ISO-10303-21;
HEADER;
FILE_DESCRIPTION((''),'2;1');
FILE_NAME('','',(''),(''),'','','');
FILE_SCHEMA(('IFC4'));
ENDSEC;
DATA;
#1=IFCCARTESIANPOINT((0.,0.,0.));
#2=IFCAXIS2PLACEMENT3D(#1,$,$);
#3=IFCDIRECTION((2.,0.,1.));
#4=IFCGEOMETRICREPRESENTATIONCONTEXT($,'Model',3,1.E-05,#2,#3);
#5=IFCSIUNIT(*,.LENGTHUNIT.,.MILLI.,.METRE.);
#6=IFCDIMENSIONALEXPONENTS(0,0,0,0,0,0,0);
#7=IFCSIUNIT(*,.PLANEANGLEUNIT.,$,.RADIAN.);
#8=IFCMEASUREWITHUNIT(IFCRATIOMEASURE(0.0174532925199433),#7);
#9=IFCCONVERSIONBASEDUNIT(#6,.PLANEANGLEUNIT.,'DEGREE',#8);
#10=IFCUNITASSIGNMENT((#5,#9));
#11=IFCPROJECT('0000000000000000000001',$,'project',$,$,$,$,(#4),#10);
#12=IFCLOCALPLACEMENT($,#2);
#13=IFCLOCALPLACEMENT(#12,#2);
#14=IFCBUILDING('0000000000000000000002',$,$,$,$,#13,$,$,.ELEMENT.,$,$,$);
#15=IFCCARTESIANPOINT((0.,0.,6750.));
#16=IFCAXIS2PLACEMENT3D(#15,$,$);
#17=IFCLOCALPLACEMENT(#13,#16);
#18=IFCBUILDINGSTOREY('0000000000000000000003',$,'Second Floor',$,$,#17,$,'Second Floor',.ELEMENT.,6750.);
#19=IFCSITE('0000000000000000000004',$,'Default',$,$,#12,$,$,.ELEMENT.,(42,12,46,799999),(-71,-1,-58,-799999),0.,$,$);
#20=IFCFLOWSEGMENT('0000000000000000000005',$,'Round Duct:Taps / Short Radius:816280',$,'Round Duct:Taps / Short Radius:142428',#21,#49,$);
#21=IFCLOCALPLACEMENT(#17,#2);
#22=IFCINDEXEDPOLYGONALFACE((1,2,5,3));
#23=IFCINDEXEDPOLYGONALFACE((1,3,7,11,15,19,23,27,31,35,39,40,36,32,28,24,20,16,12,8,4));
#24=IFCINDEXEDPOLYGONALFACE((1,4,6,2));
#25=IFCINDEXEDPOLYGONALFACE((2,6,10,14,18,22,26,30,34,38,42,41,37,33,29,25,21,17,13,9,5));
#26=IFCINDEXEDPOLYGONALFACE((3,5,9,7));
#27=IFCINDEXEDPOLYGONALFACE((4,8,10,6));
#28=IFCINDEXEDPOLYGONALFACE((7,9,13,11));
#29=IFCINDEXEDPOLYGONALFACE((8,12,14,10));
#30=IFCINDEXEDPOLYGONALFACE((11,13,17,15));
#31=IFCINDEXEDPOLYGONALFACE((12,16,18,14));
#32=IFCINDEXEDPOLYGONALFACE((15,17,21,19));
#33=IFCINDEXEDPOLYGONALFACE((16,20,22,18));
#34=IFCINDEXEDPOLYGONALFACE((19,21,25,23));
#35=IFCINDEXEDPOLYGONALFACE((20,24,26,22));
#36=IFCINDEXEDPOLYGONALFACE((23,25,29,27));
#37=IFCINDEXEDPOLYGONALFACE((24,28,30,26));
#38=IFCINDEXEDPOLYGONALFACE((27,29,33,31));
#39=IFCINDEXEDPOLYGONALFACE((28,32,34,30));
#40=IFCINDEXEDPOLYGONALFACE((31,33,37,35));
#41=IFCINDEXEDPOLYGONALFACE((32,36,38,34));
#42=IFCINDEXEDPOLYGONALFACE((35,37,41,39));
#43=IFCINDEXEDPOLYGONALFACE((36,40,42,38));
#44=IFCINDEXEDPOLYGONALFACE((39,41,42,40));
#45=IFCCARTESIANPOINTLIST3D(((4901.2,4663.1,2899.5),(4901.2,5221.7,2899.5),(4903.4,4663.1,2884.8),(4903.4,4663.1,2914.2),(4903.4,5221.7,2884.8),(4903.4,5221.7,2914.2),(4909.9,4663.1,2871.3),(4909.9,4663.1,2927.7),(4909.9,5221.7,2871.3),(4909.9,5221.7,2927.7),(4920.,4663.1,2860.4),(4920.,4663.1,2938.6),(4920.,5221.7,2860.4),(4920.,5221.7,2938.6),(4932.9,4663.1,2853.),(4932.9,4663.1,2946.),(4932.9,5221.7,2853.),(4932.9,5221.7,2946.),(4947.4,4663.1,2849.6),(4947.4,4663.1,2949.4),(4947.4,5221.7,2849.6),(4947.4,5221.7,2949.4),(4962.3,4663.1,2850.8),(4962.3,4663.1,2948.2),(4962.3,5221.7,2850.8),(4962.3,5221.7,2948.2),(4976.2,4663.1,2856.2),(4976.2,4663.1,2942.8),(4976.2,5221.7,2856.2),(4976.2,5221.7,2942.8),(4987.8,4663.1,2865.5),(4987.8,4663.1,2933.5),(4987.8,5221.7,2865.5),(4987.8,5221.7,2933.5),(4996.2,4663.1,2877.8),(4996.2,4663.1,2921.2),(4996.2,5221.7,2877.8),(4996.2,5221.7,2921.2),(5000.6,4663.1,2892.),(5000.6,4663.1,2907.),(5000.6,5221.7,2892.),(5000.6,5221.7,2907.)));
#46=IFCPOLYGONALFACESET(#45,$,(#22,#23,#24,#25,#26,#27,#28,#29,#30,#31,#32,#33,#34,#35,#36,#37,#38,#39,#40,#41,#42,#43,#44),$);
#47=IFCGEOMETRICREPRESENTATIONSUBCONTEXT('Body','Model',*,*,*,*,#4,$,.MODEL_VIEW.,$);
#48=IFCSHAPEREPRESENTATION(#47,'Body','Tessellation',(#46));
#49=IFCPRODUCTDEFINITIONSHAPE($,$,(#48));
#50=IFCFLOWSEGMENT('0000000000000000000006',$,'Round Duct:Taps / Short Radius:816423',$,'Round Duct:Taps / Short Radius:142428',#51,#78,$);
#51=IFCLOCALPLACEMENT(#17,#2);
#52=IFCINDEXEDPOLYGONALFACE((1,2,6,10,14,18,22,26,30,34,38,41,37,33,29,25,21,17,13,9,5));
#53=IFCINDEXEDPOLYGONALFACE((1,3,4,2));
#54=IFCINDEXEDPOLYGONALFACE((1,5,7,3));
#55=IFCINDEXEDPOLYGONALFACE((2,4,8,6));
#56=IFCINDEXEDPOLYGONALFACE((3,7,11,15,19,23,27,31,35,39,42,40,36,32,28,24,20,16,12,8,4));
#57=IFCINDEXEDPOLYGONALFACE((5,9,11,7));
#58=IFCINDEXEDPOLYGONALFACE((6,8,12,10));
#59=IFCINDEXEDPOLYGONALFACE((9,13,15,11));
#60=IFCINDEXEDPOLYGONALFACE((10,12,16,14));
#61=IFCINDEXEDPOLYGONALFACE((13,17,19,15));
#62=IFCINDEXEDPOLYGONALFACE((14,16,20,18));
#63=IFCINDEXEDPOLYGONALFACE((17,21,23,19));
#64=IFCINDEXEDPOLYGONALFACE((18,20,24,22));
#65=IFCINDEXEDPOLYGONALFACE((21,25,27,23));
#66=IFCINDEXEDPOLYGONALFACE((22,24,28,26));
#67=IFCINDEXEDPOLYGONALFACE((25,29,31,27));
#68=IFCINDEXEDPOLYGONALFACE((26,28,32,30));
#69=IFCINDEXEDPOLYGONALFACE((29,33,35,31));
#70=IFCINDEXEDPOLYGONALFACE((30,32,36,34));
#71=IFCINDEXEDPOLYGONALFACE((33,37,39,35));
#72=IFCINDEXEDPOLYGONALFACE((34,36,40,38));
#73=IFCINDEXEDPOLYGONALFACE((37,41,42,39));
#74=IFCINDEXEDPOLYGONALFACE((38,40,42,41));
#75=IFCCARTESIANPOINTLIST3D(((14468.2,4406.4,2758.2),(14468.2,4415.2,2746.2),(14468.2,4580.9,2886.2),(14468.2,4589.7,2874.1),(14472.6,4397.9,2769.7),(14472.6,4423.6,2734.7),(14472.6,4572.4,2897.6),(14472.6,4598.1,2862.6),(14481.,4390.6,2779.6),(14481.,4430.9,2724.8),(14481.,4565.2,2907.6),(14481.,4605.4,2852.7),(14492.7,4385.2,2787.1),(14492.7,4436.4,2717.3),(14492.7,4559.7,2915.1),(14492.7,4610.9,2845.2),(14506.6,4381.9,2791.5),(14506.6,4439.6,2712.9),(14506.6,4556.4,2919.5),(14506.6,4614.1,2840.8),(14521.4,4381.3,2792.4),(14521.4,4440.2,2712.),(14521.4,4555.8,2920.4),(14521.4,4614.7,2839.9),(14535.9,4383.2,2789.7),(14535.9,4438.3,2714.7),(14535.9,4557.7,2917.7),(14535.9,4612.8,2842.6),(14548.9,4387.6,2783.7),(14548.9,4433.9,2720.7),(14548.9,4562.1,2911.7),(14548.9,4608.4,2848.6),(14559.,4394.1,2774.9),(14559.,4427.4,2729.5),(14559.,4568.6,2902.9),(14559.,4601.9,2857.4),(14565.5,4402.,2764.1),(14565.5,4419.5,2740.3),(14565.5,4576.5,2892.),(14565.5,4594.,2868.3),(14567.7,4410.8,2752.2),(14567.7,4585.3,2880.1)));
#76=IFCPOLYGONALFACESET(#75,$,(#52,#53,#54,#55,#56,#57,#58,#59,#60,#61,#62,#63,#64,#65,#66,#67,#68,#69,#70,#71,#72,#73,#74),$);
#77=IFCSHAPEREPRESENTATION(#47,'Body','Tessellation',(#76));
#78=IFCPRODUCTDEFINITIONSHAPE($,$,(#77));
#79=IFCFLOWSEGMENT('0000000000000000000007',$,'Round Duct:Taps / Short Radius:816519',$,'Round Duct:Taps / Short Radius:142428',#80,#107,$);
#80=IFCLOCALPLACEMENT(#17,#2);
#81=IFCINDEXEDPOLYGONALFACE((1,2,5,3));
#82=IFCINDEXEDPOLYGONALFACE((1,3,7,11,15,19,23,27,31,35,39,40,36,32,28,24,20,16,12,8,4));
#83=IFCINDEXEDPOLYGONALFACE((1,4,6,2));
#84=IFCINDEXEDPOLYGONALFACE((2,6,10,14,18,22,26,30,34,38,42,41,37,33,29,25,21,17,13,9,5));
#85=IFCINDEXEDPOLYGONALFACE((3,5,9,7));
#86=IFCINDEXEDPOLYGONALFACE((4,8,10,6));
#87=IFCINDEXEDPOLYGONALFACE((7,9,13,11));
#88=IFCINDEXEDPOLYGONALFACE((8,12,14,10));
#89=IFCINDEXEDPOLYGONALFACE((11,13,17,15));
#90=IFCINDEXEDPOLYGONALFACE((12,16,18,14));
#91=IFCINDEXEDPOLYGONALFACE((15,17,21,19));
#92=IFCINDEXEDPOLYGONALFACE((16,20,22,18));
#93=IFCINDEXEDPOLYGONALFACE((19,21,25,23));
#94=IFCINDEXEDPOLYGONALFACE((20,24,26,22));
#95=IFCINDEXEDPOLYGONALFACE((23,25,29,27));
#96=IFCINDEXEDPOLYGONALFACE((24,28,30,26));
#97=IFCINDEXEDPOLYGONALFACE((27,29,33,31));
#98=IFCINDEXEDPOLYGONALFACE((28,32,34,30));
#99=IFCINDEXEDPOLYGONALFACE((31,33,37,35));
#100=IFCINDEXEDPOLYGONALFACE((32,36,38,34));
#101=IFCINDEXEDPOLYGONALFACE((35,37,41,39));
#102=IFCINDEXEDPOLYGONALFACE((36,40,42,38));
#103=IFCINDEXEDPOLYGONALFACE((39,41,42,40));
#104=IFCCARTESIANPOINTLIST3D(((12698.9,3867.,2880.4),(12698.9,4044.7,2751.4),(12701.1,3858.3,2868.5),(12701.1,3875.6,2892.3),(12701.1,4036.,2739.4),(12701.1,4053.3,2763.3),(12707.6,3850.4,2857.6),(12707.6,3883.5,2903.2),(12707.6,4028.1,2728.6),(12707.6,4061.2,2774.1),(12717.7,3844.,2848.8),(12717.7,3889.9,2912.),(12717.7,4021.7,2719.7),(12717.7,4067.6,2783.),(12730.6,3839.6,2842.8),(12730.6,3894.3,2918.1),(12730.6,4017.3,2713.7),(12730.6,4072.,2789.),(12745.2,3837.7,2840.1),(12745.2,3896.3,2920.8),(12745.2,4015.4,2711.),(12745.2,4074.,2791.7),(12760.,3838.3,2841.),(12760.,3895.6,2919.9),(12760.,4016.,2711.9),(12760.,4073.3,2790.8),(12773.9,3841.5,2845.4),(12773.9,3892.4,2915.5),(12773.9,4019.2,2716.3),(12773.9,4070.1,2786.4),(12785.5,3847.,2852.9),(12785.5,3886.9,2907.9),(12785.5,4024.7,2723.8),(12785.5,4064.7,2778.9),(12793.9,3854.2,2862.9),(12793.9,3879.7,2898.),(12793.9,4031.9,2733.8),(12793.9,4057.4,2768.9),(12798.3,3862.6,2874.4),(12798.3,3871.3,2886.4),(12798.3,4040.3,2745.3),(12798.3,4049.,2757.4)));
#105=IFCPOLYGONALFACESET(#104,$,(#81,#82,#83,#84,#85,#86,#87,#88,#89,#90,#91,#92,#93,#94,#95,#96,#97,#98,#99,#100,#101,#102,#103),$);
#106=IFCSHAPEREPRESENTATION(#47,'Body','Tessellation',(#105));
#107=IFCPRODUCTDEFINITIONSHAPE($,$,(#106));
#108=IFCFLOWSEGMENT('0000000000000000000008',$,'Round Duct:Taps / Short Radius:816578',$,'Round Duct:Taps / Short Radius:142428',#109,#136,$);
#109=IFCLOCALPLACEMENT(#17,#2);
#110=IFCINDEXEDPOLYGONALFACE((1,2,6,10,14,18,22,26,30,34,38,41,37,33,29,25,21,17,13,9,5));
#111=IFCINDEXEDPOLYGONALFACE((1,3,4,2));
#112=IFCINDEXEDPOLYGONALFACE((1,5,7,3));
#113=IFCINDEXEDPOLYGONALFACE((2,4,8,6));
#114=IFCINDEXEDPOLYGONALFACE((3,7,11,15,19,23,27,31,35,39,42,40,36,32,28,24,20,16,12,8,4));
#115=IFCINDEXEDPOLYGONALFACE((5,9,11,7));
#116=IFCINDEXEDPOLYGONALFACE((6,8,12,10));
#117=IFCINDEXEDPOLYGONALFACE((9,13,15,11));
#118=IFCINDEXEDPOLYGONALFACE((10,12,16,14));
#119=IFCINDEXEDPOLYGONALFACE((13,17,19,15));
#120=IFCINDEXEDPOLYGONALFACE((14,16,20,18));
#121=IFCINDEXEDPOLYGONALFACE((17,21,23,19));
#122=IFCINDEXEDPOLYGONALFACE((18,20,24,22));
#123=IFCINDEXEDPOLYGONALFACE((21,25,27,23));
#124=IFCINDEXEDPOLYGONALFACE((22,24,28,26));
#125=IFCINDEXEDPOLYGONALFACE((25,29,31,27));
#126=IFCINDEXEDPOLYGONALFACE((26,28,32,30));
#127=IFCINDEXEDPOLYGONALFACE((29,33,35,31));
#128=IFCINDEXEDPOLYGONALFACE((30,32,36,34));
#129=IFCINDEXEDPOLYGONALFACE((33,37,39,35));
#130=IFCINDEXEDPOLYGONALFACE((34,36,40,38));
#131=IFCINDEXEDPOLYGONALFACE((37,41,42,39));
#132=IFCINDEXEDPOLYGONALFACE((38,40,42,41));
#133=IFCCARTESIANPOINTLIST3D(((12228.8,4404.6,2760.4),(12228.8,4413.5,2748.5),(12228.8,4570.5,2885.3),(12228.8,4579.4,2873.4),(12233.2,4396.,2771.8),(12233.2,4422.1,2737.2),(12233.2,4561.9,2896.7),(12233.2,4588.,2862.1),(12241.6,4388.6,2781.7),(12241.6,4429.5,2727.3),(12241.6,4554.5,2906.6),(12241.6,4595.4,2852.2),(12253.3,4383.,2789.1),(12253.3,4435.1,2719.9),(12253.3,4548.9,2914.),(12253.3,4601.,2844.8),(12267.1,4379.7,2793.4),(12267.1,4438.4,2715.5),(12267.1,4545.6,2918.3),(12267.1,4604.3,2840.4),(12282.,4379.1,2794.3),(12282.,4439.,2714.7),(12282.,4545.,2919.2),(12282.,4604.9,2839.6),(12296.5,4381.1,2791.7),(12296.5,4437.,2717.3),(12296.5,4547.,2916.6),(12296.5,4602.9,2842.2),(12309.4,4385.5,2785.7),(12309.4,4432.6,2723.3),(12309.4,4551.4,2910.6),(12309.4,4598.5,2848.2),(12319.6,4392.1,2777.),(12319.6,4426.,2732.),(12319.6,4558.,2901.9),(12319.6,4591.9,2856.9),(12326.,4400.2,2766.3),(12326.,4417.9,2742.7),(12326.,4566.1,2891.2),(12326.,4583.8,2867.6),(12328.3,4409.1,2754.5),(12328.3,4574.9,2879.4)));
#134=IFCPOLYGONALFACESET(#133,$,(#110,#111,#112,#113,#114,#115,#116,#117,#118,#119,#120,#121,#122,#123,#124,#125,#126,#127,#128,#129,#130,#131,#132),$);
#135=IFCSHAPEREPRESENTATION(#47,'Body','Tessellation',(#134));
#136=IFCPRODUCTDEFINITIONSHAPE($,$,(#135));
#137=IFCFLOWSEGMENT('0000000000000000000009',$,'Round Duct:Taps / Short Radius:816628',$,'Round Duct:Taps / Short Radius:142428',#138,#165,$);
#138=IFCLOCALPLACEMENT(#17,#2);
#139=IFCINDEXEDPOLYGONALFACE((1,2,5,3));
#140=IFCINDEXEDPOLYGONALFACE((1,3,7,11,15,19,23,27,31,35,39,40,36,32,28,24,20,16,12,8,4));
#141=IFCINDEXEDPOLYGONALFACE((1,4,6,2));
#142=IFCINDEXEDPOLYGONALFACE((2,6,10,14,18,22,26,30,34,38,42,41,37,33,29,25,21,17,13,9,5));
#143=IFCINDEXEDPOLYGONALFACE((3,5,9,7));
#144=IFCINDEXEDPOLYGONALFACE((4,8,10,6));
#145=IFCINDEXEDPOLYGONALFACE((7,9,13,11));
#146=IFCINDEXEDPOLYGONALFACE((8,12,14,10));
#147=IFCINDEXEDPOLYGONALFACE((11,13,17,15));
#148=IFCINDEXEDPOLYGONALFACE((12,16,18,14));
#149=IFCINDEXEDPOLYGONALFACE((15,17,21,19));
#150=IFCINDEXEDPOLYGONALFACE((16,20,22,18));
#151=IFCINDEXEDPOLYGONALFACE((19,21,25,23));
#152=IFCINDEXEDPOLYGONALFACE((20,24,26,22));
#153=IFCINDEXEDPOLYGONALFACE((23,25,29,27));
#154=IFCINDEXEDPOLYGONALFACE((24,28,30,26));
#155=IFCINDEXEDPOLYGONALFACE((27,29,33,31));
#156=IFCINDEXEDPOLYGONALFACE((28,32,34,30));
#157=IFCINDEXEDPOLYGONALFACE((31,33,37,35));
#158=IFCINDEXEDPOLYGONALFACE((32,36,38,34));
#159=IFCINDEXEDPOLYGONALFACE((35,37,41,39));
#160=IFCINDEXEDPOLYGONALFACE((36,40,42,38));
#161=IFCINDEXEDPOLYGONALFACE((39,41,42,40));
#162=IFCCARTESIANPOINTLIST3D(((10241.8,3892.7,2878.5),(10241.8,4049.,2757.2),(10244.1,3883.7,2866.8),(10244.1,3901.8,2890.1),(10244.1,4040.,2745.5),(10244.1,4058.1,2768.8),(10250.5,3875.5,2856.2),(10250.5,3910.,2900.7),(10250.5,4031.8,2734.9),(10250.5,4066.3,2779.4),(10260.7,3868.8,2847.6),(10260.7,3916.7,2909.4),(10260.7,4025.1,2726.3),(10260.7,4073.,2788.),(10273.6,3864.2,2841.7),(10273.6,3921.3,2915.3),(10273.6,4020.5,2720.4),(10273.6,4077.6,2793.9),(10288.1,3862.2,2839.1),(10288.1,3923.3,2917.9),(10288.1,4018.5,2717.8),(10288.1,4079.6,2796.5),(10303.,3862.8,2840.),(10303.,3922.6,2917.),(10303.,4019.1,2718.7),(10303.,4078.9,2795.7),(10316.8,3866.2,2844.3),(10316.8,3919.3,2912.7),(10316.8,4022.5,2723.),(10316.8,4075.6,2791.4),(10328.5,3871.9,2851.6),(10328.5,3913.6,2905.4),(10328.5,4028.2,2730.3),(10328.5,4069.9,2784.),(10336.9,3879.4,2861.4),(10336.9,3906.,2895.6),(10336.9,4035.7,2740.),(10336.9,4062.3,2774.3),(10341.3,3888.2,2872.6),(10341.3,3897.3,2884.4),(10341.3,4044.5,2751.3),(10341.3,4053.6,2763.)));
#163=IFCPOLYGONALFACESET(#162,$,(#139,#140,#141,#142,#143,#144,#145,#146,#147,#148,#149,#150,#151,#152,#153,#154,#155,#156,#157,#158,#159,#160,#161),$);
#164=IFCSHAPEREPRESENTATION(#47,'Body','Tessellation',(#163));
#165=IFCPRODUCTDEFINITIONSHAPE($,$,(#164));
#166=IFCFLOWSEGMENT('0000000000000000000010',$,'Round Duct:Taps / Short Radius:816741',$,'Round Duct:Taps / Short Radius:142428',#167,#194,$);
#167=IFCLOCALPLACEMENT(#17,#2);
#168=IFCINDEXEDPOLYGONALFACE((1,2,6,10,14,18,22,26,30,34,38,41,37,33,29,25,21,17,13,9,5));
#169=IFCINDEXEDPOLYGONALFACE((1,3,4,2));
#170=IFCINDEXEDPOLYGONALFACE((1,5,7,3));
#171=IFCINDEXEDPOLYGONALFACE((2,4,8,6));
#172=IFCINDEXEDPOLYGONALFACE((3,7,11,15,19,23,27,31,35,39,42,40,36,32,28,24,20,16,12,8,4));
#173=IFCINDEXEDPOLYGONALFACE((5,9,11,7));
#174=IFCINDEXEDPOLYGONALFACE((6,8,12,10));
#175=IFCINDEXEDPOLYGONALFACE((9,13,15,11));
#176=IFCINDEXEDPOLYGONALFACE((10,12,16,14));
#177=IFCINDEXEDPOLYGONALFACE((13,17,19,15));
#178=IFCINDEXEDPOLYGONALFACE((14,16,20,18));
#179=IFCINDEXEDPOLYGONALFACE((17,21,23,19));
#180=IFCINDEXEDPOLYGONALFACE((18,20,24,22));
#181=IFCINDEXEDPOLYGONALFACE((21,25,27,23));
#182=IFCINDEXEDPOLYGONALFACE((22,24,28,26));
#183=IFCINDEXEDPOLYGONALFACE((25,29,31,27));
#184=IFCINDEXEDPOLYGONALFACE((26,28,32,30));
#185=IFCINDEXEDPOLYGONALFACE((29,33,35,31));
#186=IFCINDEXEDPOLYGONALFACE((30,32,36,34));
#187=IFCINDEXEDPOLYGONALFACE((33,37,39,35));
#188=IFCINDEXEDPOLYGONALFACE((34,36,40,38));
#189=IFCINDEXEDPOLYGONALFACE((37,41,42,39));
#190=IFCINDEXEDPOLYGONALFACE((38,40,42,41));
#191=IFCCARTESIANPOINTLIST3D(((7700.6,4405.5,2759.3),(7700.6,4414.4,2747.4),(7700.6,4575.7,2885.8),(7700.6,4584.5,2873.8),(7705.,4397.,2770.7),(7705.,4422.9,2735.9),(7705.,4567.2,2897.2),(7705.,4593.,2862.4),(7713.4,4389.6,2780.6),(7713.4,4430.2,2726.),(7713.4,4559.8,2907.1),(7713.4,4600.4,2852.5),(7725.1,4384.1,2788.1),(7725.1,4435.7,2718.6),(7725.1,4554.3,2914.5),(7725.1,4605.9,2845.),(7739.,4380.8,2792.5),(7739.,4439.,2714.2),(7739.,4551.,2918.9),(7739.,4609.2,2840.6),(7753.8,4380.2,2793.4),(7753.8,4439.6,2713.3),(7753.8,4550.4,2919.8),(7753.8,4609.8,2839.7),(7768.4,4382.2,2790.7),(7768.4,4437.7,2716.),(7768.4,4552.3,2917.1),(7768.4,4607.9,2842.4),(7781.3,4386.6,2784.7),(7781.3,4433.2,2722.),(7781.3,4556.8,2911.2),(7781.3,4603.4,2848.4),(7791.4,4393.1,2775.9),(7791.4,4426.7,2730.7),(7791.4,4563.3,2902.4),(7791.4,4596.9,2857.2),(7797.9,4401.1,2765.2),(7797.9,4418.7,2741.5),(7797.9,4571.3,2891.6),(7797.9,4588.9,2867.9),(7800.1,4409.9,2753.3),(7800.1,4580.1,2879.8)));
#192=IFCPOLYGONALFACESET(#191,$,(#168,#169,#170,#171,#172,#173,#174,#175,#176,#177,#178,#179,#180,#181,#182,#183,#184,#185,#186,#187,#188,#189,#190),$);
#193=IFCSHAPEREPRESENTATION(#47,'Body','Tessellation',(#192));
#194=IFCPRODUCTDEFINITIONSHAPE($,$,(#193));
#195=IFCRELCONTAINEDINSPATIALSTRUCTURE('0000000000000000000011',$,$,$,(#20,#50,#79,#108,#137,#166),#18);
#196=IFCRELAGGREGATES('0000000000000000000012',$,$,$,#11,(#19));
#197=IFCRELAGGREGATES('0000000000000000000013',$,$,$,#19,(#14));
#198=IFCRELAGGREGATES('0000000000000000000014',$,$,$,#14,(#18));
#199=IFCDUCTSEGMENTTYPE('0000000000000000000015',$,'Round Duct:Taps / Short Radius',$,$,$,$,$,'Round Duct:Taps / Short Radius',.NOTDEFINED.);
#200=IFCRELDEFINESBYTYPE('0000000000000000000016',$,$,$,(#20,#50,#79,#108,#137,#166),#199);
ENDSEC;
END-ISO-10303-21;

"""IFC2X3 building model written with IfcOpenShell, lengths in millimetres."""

from ifc_helpers import new_model, entity, si_unit, converted_unit, direction, frame, frame_2d, origin, place, context, subcontext, project, spatial, circle, extrude, type_object, element, save


model = new_model("IFC2X3")

# Units and contexts
model_context = context("Model", 3, precision=1e-05, world=origin(), true_north=direction((2.0, 0.0, 1.0)))
body_context = subcontext(model_context, "Body", "Model", "MODEL_VIEW")
ifc_project = project(units=[si_unit("LENGTHUNIT", "METRE", prefix="MILLI"), converted_unit("PLANEANGLEUNIT", "DEGREE", entity("IfcRatioMeasure", 0.0174532925199433), si_unit("PLANEANGLEUNIT", "RADIAN"), dimensions=[0, 0, 0, 0, 0, 0, 0])], contexts=[model_context])

# Site, building, storey
site_placement = place(None, origin())
site = spatial("IfcSite", under=ifc_project, at=site_placement, Name="Default", CompositionType="ELEMENT", RefLatitude=(42, 12, 46, 799999), RefLongitude=(-71, -1, -58, -799999), RefElevation=0.0)
building_placement = place(site_placement, origin())
building = spatial("IfcBuilding", under=site, at=building_placement, CompositionType="ELEMENT")
storey_placement = place(building_placement, frame((0.0, 0.0, 6750.0)))
storey = spatial("IfcBuildingStorey", under=building, at=storey_placement, Name="Second Floor", LongName="Second Floor", CompositionType="ELEMENT", Elevation=6750.0)

# Flow segments
duct_segment_type = type_object("IfcDuctSegmentType", Name="Round Duct:Taps / Short Radius", ElementType="Round Duct:Taps / Short Radius", PredefinedType="NOTDEFINED")
flow_segment_1_placement = place(storey_placement, origin())
element("IfcFlowSegment", 1, at=flow_segment_1_placement, inside=storey, type_object=duct_segment_type, Name="Round Duct:Taps / Short Radius:816280", ObjectType="Round Duct:Taps / Short Radius:142428", context=body_context, shape_type="SweptSolid", body=[
    extrude(circle(Radius=50.0, at=frame_2d((0.0, 0.0), x_axis=(1.0, 0.0))), frame((4951.2, 4663.1, 2899.5), z_axis=(0.0, 1.0, 0.0), x_axis=(-1.0, 0.0, 0.0)), (0.0, 0.0, 1.0), 558.6),
])
flow_segment_2_placement = place(storey_placement, origin())
element("IfcFlowSegment", 2, at=flow_segment_2_placement, inside=storey, type_object=duct_segment_type, Name="Round Duct:Taps / Short Radius:816423", ObjectType="Round Duct:Taps / Short Radius:142428", context=body_context, shape_type="SweptSolid", body=[
    extrude(circle(Radius=50.0, at=frame_2d((0.0, 0.0), x_axis=(1.0, 0.0))), frame((14517.7, 4410.8, 2752.2), z_axis=(0.0, 0.806442, 0.591313), x_axis=(1.0, 0.0, 0.0)), (0.0, 0.0, 1.0), 216.4),
])
flow_segment_3_placement = place(storey_placement, origin())
element("IfcFlowSegment", 3, at=flow_segment_3_placement, inside=storey, type_object=duct_segment_type, Name="Round Duct:Taps / Short Radius:816519", ObjectType="Round Duct:Taps / Short Radius:142428", context=body_context, shape_type="SweptSolid", body=[
    extrude(circle(Radius=50.0, at=frame_2d((0.0, 0.0), x_axis=(1.0, 0.0))), frame((12748.9, 4044.7, 2751.4), z_axis=(0.0, -0.809139, 0.587617), x_axis=(-1.0, 0.0, 0.0)), (0.0, 0.0, 1.0), 219.6),
])
flow_segment_4_placement = place(storey_placement, origin())
element("IfcFlowSegment", 4, at=flow_segment_4_placement, inside=storey, type_object=duct_segment_type, Name="Round Duct:Taps / Short Radius:816578", ObjectType="Round Duct:Taps / Short Radius:142428", context=body_context, shape_type="SweptSolid", body=[
    extrude(circle(Radius=50.0, at=frame_2d((0.0, 0.0), x_axis=(1.0, 0.0))), frame((12278.3, 4409.1, 2754.5), z_axis=(0.0, 0.798902, 0.601462), x_axis=(1.0, 0.0, 0.0)), (0.0, 0.0, 1.0), 207.7),
])
flow_segment_5_placement = place(storey_placement, origin())
element("IfcFlowSegment", 5, at=flow_segment_5_placement, inside=storey, type_object=duct_segment_type, Name="Round Duct:Taps / Short Radius:816628", ObjectType="Round Duct:Taps / Short Radius:142428", context=body_context, shape_type="SweptSolid", body=[
    extrude(circle(Radius=50.0, at=frame_2d((0.0, 0.0), x_axis=(1.0, 0.0))), frame((10291.8, 4049.0, 2757.2), z_axis=(0.0, -0.789906, 0.613228), x_axis=(-1.0, 0.0, 0.0)), (0.0, 0.0, 1.0), 197.9),
])
flow_segment_6_placement = place(storey_placement, origin())
element("IfcFlowSegment", 6, at=flow_segment_6_placement, inside=storey, type_object=duct_segment_type, Name="Round Duct:Taps / Short Radius:816741", ObjectType="Round Duct:Taps / Short Radius:142428", context=body_context, shape_type="SweptSolid", body=[
    extrude(circle(Radius=50.0, at=frame_2d((0.0, 0.0), x_axis=(1.0, 0.0))), frame((7750.1, 4409.9, 2753.3), z_axis=(0.0, 0.80272, 0.596356), x_axis=(1.0, 0.0, 0.0)), (0.0, 0.0, 1.0), 212.0),
])

save(model, "model.ifc")
